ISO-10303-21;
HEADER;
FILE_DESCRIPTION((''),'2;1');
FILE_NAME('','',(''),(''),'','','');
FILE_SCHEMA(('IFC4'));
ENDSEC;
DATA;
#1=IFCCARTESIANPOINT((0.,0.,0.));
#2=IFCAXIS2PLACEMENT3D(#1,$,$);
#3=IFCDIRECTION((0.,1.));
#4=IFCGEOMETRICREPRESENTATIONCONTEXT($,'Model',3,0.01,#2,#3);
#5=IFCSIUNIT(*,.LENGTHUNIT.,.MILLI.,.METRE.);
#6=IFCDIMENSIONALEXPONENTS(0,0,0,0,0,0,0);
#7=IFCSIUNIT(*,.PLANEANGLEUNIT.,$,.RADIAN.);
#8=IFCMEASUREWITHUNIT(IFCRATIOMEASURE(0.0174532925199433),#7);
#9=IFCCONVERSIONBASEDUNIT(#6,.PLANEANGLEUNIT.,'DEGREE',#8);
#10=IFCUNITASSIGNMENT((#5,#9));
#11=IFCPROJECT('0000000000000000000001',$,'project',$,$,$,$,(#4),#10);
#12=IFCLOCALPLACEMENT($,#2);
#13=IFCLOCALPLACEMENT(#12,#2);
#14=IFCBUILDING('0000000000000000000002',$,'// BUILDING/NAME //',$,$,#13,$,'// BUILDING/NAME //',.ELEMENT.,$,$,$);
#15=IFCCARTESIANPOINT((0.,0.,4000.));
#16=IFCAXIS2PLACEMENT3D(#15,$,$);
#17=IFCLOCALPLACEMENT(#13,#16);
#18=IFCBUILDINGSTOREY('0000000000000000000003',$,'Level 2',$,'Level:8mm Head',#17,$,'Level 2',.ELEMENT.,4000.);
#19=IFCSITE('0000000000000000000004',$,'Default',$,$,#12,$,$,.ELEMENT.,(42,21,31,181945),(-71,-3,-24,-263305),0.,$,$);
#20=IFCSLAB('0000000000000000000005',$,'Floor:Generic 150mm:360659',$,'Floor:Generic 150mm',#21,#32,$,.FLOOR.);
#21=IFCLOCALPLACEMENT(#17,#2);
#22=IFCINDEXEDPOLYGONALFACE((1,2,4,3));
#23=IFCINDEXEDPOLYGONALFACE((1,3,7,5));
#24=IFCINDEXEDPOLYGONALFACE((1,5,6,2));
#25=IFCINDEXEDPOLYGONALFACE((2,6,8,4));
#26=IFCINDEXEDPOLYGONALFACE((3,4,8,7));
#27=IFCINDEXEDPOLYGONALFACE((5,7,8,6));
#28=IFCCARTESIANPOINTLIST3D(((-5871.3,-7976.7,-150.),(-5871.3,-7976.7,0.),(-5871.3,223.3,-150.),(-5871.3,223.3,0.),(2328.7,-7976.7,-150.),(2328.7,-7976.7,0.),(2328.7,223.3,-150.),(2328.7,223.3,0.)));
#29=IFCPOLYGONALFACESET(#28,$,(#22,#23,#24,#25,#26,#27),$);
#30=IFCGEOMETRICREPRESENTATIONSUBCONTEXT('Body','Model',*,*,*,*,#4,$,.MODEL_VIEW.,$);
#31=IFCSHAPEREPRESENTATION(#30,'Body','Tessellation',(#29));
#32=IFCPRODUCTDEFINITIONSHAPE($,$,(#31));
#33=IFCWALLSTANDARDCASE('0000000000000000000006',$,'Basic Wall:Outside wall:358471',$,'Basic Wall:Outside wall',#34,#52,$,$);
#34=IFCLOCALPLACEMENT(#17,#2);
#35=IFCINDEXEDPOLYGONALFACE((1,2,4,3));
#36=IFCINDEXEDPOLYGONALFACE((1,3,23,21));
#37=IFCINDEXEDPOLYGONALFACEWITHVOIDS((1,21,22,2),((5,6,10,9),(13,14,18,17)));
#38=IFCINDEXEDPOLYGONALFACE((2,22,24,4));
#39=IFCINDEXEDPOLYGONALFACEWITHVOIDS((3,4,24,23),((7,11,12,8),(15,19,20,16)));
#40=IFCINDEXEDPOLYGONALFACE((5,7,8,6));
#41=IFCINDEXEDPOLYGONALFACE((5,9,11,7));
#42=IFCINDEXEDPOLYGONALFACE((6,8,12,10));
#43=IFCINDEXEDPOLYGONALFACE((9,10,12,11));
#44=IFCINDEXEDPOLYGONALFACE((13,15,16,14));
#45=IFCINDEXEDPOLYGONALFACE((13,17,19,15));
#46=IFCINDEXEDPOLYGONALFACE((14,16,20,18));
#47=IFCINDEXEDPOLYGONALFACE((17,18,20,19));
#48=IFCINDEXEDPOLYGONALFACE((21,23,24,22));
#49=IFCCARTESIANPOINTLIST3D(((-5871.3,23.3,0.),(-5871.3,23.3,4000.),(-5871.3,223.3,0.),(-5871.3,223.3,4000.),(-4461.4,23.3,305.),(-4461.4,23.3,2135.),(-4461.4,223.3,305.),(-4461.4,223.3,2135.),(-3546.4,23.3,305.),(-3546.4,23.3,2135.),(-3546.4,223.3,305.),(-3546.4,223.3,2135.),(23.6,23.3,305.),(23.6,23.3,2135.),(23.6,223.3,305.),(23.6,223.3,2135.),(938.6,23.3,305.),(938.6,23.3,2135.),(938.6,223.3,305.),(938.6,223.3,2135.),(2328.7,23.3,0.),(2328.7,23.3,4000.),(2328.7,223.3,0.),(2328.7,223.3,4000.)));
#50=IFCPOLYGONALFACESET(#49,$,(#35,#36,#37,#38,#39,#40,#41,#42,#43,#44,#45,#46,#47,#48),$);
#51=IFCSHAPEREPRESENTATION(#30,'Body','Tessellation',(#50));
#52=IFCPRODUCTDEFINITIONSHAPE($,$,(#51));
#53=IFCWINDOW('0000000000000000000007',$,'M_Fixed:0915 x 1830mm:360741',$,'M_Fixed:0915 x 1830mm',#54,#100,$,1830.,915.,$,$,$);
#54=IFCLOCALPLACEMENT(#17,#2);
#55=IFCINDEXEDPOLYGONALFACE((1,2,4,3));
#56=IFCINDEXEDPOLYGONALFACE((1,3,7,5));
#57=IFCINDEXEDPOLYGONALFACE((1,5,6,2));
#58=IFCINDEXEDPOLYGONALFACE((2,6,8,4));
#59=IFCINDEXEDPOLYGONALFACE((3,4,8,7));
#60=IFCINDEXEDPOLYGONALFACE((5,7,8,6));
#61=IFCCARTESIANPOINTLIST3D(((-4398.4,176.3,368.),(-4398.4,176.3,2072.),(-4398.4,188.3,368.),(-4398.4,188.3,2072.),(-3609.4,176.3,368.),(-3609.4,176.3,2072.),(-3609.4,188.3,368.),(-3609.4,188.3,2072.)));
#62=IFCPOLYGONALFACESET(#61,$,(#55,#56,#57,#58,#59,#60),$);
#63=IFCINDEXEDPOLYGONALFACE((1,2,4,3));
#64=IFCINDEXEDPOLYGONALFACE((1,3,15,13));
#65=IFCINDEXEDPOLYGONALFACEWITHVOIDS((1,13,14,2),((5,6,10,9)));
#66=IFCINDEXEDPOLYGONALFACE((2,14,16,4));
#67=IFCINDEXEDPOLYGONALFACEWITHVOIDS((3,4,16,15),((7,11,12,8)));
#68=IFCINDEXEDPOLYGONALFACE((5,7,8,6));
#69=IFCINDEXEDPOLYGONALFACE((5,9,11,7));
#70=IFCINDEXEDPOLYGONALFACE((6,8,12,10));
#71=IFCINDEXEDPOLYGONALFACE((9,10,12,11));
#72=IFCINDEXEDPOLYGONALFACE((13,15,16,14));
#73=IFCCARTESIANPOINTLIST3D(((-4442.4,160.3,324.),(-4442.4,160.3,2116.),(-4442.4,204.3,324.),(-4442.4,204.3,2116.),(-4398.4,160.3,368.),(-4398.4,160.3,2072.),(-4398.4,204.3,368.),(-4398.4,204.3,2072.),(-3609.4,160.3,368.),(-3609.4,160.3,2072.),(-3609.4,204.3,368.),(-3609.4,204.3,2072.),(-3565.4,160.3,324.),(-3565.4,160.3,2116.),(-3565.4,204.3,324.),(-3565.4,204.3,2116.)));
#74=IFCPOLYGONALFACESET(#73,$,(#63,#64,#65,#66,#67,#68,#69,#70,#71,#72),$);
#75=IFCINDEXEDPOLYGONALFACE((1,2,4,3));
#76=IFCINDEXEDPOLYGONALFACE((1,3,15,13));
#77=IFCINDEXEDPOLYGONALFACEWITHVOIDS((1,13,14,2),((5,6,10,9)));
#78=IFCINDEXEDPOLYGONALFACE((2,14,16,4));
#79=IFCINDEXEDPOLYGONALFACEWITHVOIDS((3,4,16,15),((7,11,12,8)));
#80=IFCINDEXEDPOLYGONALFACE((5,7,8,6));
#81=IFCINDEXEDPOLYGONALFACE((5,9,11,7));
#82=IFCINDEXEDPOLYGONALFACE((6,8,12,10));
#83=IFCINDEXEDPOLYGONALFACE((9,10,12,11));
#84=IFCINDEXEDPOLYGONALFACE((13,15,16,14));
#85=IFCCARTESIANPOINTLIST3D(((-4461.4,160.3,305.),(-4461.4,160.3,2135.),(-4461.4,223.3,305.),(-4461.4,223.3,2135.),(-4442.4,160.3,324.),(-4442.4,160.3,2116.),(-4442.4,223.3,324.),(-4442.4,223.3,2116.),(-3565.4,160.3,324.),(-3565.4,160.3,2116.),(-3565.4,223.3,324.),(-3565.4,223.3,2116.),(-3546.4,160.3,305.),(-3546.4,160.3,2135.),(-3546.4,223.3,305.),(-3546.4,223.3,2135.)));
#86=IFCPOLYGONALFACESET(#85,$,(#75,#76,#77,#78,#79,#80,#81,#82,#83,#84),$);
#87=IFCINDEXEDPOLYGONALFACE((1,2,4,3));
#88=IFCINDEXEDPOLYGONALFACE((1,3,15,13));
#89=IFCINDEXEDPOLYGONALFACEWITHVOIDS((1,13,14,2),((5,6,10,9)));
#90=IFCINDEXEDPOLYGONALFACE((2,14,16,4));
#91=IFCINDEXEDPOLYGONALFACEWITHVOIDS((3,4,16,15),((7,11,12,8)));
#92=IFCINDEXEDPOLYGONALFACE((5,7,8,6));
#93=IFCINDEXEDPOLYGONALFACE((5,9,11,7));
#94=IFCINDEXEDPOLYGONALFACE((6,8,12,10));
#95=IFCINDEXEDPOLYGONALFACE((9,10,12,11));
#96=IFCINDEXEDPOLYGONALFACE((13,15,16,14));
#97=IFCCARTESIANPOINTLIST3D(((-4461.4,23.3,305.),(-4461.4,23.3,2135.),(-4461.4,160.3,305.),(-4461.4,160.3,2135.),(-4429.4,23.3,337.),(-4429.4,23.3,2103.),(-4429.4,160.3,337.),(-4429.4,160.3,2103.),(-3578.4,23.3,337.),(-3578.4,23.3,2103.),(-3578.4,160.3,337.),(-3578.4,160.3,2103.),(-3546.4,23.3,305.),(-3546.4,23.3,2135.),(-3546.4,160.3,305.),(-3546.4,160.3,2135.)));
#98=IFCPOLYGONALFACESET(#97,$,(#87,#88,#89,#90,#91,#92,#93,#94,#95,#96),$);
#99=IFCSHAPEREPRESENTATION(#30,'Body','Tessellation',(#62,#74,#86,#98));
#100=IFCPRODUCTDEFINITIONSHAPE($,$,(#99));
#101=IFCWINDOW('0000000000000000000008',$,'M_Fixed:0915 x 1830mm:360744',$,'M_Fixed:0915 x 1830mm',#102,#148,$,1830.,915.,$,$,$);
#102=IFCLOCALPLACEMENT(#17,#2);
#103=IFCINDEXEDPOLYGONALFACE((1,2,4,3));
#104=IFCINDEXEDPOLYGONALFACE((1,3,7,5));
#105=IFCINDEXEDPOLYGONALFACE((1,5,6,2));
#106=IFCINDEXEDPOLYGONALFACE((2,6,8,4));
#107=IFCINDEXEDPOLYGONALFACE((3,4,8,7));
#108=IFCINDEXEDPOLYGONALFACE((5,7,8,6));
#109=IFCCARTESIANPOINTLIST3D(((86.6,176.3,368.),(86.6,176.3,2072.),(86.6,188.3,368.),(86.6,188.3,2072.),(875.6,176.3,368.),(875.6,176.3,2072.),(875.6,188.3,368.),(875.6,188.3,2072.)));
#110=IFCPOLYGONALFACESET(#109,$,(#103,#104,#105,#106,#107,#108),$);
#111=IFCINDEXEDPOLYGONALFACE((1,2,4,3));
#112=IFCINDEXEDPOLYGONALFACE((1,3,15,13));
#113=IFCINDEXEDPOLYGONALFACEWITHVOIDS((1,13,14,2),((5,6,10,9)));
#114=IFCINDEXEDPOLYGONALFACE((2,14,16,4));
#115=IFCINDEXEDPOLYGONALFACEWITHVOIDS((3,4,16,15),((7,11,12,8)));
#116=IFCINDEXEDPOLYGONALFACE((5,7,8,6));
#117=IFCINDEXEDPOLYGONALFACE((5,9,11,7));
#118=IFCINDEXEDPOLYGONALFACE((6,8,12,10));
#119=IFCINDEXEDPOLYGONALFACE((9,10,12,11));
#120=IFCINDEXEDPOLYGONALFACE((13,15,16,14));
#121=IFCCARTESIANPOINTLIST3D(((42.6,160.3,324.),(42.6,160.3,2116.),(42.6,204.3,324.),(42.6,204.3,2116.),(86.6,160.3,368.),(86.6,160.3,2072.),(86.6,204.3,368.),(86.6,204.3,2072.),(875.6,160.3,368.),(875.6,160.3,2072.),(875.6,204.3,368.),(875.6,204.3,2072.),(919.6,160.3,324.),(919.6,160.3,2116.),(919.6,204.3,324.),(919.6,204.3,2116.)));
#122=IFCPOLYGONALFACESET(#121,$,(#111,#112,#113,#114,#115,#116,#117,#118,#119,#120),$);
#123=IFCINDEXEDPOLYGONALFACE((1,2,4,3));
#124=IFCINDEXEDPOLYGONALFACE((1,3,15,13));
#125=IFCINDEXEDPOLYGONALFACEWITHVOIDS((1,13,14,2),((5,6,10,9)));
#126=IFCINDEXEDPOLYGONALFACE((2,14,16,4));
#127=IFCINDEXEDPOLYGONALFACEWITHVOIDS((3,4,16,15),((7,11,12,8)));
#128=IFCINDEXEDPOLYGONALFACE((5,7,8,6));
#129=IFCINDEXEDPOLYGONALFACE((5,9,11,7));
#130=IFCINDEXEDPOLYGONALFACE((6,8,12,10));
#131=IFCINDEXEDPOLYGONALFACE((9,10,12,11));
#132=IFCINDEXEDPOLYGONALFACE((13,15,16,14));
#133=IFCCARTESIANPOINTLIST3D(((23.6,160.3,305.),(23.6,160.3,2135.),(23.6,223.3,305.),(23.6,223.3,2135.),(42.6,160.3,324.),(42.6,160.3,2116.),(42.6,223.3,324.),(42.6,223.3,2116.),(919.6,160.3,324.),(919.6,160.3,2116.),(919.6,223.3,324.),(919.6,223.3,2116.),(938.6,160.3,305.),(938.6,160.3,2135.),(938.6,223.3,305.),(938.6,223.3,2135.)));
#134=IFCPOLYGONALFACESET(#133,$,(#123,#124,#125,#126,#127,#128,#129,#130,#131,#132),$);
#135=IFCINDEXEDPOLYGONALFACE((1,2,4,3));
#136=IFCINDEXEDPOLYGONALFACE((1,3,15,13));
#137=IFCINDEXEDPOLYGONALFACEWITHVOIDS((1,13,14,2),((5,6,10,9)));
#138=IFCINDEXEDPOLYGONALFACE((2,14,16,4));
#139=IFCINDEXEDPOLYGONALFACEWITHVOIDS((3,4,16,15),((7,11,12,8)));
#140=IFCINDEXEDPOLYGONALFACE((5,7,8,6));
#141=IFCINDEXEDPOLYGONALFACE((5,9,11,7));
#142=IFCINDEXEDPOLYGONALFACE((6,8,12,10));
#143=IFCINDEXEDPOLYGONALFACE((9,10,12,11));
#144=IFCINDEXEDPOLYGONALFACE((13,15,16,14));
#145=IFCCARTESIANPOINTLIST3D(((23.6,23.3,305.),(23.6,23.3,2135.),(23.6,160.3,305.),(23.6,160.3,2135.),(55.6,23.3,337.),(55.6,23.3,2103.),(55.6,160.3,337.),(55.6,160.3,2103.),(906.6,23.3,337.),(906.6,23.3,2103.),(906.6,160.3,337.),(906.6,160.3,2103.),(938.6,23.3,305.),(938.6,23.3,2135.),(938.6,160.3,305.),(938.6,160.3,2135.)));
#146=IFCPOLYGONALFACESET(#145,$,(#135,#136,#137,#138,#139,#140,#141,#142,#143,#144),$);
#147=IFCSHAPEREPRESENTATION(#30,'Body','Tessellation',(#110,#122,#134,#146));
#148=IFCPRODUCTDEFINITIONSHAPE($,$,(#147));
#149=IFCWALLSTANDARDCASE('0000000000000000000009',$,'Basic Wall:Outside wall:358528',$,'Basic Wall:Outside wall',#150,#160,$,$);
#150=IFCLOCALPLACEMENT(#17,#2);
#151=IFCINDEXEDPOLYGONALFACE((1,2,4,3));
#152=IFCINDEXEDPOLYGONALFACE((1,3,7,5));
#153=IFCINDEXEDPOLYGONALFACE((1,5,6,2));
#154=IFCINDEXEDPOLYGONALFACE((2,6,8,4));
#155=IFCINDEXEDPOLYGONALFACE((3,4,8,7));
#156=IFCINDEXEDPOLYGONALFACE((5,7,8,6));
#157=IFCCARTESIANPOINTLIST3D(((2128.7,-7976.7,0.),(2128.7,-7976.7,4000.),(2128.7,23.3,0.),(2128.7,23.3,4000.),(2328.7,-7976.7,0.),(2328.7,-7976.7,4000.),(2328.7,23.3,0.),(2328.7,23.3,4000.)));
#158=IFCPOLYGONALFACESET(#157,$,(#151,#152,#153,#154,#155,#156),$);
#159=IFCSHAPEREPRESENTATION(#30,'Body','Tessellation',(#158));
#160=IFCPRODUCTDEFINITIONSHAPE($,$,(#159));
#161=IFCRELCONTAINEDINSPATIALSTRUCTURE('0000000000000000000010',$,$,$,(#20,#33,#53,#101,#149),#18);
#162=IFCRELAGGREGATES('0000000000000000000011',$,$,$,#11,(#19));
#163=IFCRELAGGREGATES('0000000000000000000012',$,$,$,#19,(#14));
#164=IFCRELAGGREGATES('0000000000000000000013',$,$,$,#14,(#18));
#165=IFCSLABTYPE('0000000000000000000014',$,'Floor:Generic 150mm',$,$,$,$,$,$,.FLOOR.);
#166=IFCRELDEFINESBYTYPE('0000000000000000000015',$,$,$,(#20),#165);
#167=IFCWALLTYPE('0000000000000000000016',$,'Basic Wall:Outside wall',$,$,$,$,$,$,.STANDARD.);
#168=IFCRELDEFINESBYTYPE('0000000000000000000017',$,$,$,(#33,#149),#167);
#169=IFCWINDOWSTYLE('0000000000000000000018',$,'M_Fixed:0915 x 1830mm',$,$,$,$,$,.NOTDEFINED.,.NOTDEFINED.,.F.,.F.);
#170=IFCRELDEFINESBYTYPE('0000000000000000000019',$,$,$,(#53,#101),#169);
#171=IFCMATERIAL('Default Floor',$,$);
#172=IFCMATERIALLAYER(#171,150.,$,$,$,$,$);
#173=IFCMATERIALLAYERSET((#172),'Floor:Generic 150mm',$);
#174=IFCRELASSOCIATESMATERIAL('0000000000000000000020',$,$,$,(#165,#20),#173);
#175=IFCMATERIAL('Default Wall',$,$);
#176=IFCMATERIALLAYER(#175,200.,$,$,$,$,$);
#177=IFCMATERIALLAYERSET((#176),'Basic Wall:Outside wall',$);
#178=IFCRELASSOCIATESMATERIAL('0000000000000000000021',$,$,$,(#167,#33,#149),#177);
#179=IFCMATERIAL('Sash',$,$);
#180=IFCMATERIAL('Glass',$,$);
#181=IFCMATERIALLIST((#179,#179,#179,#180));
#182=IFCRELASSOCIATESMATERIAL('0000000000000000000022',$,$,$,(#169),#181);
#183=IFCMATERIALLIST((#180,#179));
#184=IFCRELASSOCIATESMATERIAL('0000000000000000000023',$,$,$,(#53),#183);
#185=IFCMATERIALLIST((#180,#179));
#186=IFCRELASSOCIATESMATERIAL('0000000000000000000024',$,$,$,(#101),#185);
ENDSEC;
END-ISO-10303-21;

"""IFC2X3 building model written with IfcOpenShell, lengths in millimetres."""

from ifc_helpers import new_model, entity, si_unit, converted_unit, direction, frame, frame_2d, origin, place, context, subcontext, project, spatial, polyline, rectangle, outline, extrude, clip, halfspace, source, transform, mapped, material, material_list, layer, layer_set, layer_usage, type_object, type_shapes, element, fill, save


model = new_model("IFC2X3")

# Units and contexts
model_context = context("Model", 3, precision=0.01, world=origin(), true_north=direction((0.0, 1.0)))
body_context = subcontext(model_context, "Body", "Model", "MODEL_VIEW")
ifc_project = project(units=[si_unit("LENGTHUNIT", "METRE", prefix="MILLI"), converted_unit("PLANEANGLEUNIT", "DEGREE", entity("IfcRatioMeasure", 0.0174532925199433), si_unit("PLANEANGLEUNIT", "RADIAN"), dimensions=[0, 0, 0, 0, 0, 0, 0])], contexts=[model_context])

# Site, building, storey
site_placement = place(None, origin())
site = spatial("IfcSite", under=ifc_project, at=site_placement, Name="Default", CompositionType="ELEMENT", RefLatitude=(42, 21, 31, 181945), RefLongitude=(-71, -3, -24, -263305), RefElevation=0.0)
building_placement = place(site_placement, origin())
building = spatial("IfcBuilding", under=site, at=building_placement, Name="// BUILDING/NAME //", LongName="// BUILDING/NAME //", CompositionType="ELEMENT")
storey_placement = place(building_placement, frame((0.0, 0.0, 4000.0)))
storey = spatial("IfcBuildingStorey", under=building, at=storey_placement, Name="Level 2", ObjectType="Level:8mm Head", LongName="Level 2", CompositionType="ELEMENT", Elevation=4000.0)

# Slab
ifc_material_1 = material(Name="Default Floor")
ifc_layer_1 = layer(ifc_material_1, 150.0)
ifc_layer_set_1 = layer_set([ifc_layer_1], Name="Floor:Generic 150mm")
ifc_layer_usage_1 = layer_usage(ifc_layer_set_1, "AXIS3", "POSITIVE", 0.0)
slab_type = type_object("IfcSlabType", Name="Floor:Generic 150mm", PredefinedType="FLOOR", material=ifc_layer_set_1)
slab_placement = place(storey_placement, origin())
element("IfcSlab", 1, at=slab_placement, inside=storey, type_object=slab_type, material=ifc_layer_usage_1, Name="Floor:Generic 150mm:360659", ObjectType="Floor:Generic 150mm", PredefinedType="FLOOR", context=body_context, shape_type="SweptSolid", body=[
    extrude(rectangle(XDim=8200.0, YDim=8200.0, at=frame_2d((0.0, 0.0), x_axis=(1.0, 0.0))), frame((-1771.3, -3876.7, 0.0), z_axis=(0.0, 0.0, -1.0), x_axis=(0.0, 1.0, 0.0)), (0.0, 0.0, 1.0), 150.0),
])

# Wall, openings, windows
ifc_material_2 = material(Name="Default Wall")
ifc_layer_2 = layer(ifc_material_2, 200.0)
ifc_layer_set_2 = layer_set([ifc_layer_2], Name="Basic Wall:Outside wall")
ifc_layer_usage_2 = layer_usage(ifc_layer_set_2, "AXIS2", "NEGATIVE", 100.0)
wall_type_1 = type_object("IfcWallType", Name="Basic Wall:Outside wall", PredefinedType="STANDARD", material=ifc_layer_set_2)
wall_1_placement = place(storey_placement, frame((-5871.3, 123.3, 0.0)))
wall_1 = element("IfcWallStandardCase", 2, at=wall_1_placement, inside=storey, type_object=wall_type_1, material=ifc_layer_usage_2, Name="Basic Wall:Outside wall:358471", ObjectType="Basic Wall:Outside wall", context=body_context, shape_type="Clipping", body=[
    clip(extrude(rectangle(XDim=8200.0, YDim=200.0, at=frame_2d((4100.0, 0.0), x_axis=(-1.0, 0.0))), origin(), (0.0, 0.0, 1.0), 4000.0), halfspace(frame((0.0, 0.0, -4000.0)), True)),
])
opening_1_placement = place(wall_1_placement, frame((1409.9, -100.0, 305.0)))
opening_1 = element("IfcOpeningElement", 3, at=opening_1_placement, cuts=wall_1, ObjectType="Opening", context=body_context, shape_type="SweptSolid", body=[
    extrude(rectangle(XDim=1830.0, YDim=915.0, at=frame_2d((915.0, 457.5), x_axis=(1.0, 0.0))), frame((0.0, 0.0, 0.0), z_axis=(0.0, 1.0, 0.0), x_axis=(0.0, 0.0, 1.0)), (0.0, 0.0, 1.0), 200.0),
])
opening_2_placement = place(wall_1_placement, frame((5894.9, -100.0, 305.0)))
opening_2 = element("IfcOpeningElement", 4, at=opening_2_placement, cuts=wall_1, ObjectType="Opening", context=body_context, shape_type="SweptSolid", body=[
    extrude(rectangle(XDim=1830.0, YDim=915.0, at=frame_2d((915.0, 457.5), x_axis=(1.0, 0.0))), frame((0.0, 0.0, 0.0), z_axis=(0.0, 1.0, 0.0), x_axis=(0.0, 0.0, 1.0)), (0.0, 0.0, 1.0), 200.0),
])
ifc_material_3 = material(Name="Glass")
ifc_material_4 = material(Name="Sash")
ifc_material_list_1 = material_list([ifc_material_3, ifc_material_4])
ifc_material_list_2 = material_list([ifc_material_4, ifc_material_4, ifc_material_4, ifc_material_3])
window_style = type_object("IfcWindowStyle", Name="M_Fixed:0915 x 1830mm", ConstructionType="NOTDEFINED", OperationType="NOTDEFINED", ParameterTakesPrecedence=False, Sizeable=False, material=ifc_material_list_2)
shared_shape = source(origin(), body_context, "Body", "SweptSolid", [
    extrude(rectangle(XDim=12.0, YDim=789.0, at=frame_2d((0.0, 0.0), x_axis=(1.0, 0.0))), frame((457.5, 159.0, 63.0), z_axis=(0.0, 0.0, 1.0), x_axis=(0.0, -1.0, 0.0)), (0.0, 0.0, 1.0), 1704.0),
    extrude(outline(polyline([(-438.5, -896.0), (438.5, -896.0), (438.5, 896.0), (-438.5, 896.0), (-438.5, -896.0)]), holes=[polyline([(-394.5, -852.0), (-394.5, 852.0), (394.5, 852.0), (394.5, -852.0), (-394.5, -852.0)])]), frame((457.5, 137.0, 915.0), z_axis=(0.0, 1.0, 0.0), x_axis=(1.0, 0.0, 0.0)), (0.0, 0.0, 1.0), 44.0),
    extrude(outline(polyline([(-457.5, -915.0), (457.5, -915.0), (457.5, 915.0), (-457.5, 915.0), (-457.5, -915.0)]), holes=[polyline([(-438.5, -896.0), (-438.5, 896.0), (438.5, 896.0), (438.5, -896.0), (-438.5, -896.0)])]), frame((457.5, 137.0, 915.0), z_axis=(0.0, 1.0, 0.0), x_axis=(1.0, 0.0, 0.0)), (0.0, 0.0, 1.0), 63.0),
    extrude(outline(polyline([(-457.5, -915.0), (457.5, -915.0), (457.5, 915.0), (-457.5, 915.0), (-457.5, -915.0)]), holes=[polyline([(-425.5, -883.0), (-425.5, 883.0), (425.5, 883.0), (425.5, -883.0), (-425.5, -883.0)])]), frame((457.5, 0.0, 915.0), z_axis=(0.0, 1.0, 0.0), x_axis=(1.0, 0.0, 0.0)), (0.0, 0.0, 1.0), 137.0),
])
type_shapes(window_style, [shared_shape])
window_1_placement = place(opening_1_placement, origin())
window_1 = element("IfcWindow", 5, at=window_1_placement, inside=storey, type_object=window_style, material=ifc_material_list_1, Name="M_Fixed:0915 x 1830mm:360741", ObjectType="M_Fixed:0915 x 1830mm", OverallHeight=1830.0, OverallWidth=915.0, context=body_context, shape_type="MappedRepresentation", body=[
    mapped(shared_shape, transform((0.0, 0.0, 0.0), scale=1.0)),
])
fill(opening_1, window_1)
ifc_material_list_3 = material_list([ifc_material_3, ifc_material_4])
window_2_placement = place(opening_2_placement, origin())
window_2 = element("IfcWindow", 6, at=window_2_placement, inside=storey, type_object=window_style, material=ifc_material_list_3, Name="M_Fixed:0915 x 1830mm:360744", ObjectType="M_Fixed:0915 x 1830mm", OverallHeight=1830.0, OverallWidth=915.0, context=body_context, shape_type="MappedRepresentation", body=[
    mapped(shared_shape, transform((0.0, 0.0, 0.0), scale=1.0)),
])
fill(opening_2, window_2)

# Wall
ifc_layer_usage_3 = layer_usage(ifc_layer_set_2, "AXIS2", "NEGATIVE", 100.0)
wall_2_placement = place(storey_placement, frame((2228.7, 23.3, 0.0), z_axis=(0.0, 0.0, 1.0), x_axis=(0.0, -1.0, 0.0)))
element("IfcWallStandardCase", 7, at=wall_2_placement, inside=storey, type_object=wall_type_1, material=ifc_layer_usage_3, Name="Basic Wall:Outside wall:358528", ObjectType="Basic Wall:Outside wall", context=body_context, shape_type="Clipping", body=[
    clip(extrude(rectangle(XDim=8000.0, YDim=200.0, at=frame_2d((4000.0, 0.0), x_axis=(-1.0, 0.0))), origin(), (0.0, 0.0, 1.0), 4000.0), halfspace(frame((0.0, 0.0, -4000.0)), True)),
])

save(model, "model.ifc")
